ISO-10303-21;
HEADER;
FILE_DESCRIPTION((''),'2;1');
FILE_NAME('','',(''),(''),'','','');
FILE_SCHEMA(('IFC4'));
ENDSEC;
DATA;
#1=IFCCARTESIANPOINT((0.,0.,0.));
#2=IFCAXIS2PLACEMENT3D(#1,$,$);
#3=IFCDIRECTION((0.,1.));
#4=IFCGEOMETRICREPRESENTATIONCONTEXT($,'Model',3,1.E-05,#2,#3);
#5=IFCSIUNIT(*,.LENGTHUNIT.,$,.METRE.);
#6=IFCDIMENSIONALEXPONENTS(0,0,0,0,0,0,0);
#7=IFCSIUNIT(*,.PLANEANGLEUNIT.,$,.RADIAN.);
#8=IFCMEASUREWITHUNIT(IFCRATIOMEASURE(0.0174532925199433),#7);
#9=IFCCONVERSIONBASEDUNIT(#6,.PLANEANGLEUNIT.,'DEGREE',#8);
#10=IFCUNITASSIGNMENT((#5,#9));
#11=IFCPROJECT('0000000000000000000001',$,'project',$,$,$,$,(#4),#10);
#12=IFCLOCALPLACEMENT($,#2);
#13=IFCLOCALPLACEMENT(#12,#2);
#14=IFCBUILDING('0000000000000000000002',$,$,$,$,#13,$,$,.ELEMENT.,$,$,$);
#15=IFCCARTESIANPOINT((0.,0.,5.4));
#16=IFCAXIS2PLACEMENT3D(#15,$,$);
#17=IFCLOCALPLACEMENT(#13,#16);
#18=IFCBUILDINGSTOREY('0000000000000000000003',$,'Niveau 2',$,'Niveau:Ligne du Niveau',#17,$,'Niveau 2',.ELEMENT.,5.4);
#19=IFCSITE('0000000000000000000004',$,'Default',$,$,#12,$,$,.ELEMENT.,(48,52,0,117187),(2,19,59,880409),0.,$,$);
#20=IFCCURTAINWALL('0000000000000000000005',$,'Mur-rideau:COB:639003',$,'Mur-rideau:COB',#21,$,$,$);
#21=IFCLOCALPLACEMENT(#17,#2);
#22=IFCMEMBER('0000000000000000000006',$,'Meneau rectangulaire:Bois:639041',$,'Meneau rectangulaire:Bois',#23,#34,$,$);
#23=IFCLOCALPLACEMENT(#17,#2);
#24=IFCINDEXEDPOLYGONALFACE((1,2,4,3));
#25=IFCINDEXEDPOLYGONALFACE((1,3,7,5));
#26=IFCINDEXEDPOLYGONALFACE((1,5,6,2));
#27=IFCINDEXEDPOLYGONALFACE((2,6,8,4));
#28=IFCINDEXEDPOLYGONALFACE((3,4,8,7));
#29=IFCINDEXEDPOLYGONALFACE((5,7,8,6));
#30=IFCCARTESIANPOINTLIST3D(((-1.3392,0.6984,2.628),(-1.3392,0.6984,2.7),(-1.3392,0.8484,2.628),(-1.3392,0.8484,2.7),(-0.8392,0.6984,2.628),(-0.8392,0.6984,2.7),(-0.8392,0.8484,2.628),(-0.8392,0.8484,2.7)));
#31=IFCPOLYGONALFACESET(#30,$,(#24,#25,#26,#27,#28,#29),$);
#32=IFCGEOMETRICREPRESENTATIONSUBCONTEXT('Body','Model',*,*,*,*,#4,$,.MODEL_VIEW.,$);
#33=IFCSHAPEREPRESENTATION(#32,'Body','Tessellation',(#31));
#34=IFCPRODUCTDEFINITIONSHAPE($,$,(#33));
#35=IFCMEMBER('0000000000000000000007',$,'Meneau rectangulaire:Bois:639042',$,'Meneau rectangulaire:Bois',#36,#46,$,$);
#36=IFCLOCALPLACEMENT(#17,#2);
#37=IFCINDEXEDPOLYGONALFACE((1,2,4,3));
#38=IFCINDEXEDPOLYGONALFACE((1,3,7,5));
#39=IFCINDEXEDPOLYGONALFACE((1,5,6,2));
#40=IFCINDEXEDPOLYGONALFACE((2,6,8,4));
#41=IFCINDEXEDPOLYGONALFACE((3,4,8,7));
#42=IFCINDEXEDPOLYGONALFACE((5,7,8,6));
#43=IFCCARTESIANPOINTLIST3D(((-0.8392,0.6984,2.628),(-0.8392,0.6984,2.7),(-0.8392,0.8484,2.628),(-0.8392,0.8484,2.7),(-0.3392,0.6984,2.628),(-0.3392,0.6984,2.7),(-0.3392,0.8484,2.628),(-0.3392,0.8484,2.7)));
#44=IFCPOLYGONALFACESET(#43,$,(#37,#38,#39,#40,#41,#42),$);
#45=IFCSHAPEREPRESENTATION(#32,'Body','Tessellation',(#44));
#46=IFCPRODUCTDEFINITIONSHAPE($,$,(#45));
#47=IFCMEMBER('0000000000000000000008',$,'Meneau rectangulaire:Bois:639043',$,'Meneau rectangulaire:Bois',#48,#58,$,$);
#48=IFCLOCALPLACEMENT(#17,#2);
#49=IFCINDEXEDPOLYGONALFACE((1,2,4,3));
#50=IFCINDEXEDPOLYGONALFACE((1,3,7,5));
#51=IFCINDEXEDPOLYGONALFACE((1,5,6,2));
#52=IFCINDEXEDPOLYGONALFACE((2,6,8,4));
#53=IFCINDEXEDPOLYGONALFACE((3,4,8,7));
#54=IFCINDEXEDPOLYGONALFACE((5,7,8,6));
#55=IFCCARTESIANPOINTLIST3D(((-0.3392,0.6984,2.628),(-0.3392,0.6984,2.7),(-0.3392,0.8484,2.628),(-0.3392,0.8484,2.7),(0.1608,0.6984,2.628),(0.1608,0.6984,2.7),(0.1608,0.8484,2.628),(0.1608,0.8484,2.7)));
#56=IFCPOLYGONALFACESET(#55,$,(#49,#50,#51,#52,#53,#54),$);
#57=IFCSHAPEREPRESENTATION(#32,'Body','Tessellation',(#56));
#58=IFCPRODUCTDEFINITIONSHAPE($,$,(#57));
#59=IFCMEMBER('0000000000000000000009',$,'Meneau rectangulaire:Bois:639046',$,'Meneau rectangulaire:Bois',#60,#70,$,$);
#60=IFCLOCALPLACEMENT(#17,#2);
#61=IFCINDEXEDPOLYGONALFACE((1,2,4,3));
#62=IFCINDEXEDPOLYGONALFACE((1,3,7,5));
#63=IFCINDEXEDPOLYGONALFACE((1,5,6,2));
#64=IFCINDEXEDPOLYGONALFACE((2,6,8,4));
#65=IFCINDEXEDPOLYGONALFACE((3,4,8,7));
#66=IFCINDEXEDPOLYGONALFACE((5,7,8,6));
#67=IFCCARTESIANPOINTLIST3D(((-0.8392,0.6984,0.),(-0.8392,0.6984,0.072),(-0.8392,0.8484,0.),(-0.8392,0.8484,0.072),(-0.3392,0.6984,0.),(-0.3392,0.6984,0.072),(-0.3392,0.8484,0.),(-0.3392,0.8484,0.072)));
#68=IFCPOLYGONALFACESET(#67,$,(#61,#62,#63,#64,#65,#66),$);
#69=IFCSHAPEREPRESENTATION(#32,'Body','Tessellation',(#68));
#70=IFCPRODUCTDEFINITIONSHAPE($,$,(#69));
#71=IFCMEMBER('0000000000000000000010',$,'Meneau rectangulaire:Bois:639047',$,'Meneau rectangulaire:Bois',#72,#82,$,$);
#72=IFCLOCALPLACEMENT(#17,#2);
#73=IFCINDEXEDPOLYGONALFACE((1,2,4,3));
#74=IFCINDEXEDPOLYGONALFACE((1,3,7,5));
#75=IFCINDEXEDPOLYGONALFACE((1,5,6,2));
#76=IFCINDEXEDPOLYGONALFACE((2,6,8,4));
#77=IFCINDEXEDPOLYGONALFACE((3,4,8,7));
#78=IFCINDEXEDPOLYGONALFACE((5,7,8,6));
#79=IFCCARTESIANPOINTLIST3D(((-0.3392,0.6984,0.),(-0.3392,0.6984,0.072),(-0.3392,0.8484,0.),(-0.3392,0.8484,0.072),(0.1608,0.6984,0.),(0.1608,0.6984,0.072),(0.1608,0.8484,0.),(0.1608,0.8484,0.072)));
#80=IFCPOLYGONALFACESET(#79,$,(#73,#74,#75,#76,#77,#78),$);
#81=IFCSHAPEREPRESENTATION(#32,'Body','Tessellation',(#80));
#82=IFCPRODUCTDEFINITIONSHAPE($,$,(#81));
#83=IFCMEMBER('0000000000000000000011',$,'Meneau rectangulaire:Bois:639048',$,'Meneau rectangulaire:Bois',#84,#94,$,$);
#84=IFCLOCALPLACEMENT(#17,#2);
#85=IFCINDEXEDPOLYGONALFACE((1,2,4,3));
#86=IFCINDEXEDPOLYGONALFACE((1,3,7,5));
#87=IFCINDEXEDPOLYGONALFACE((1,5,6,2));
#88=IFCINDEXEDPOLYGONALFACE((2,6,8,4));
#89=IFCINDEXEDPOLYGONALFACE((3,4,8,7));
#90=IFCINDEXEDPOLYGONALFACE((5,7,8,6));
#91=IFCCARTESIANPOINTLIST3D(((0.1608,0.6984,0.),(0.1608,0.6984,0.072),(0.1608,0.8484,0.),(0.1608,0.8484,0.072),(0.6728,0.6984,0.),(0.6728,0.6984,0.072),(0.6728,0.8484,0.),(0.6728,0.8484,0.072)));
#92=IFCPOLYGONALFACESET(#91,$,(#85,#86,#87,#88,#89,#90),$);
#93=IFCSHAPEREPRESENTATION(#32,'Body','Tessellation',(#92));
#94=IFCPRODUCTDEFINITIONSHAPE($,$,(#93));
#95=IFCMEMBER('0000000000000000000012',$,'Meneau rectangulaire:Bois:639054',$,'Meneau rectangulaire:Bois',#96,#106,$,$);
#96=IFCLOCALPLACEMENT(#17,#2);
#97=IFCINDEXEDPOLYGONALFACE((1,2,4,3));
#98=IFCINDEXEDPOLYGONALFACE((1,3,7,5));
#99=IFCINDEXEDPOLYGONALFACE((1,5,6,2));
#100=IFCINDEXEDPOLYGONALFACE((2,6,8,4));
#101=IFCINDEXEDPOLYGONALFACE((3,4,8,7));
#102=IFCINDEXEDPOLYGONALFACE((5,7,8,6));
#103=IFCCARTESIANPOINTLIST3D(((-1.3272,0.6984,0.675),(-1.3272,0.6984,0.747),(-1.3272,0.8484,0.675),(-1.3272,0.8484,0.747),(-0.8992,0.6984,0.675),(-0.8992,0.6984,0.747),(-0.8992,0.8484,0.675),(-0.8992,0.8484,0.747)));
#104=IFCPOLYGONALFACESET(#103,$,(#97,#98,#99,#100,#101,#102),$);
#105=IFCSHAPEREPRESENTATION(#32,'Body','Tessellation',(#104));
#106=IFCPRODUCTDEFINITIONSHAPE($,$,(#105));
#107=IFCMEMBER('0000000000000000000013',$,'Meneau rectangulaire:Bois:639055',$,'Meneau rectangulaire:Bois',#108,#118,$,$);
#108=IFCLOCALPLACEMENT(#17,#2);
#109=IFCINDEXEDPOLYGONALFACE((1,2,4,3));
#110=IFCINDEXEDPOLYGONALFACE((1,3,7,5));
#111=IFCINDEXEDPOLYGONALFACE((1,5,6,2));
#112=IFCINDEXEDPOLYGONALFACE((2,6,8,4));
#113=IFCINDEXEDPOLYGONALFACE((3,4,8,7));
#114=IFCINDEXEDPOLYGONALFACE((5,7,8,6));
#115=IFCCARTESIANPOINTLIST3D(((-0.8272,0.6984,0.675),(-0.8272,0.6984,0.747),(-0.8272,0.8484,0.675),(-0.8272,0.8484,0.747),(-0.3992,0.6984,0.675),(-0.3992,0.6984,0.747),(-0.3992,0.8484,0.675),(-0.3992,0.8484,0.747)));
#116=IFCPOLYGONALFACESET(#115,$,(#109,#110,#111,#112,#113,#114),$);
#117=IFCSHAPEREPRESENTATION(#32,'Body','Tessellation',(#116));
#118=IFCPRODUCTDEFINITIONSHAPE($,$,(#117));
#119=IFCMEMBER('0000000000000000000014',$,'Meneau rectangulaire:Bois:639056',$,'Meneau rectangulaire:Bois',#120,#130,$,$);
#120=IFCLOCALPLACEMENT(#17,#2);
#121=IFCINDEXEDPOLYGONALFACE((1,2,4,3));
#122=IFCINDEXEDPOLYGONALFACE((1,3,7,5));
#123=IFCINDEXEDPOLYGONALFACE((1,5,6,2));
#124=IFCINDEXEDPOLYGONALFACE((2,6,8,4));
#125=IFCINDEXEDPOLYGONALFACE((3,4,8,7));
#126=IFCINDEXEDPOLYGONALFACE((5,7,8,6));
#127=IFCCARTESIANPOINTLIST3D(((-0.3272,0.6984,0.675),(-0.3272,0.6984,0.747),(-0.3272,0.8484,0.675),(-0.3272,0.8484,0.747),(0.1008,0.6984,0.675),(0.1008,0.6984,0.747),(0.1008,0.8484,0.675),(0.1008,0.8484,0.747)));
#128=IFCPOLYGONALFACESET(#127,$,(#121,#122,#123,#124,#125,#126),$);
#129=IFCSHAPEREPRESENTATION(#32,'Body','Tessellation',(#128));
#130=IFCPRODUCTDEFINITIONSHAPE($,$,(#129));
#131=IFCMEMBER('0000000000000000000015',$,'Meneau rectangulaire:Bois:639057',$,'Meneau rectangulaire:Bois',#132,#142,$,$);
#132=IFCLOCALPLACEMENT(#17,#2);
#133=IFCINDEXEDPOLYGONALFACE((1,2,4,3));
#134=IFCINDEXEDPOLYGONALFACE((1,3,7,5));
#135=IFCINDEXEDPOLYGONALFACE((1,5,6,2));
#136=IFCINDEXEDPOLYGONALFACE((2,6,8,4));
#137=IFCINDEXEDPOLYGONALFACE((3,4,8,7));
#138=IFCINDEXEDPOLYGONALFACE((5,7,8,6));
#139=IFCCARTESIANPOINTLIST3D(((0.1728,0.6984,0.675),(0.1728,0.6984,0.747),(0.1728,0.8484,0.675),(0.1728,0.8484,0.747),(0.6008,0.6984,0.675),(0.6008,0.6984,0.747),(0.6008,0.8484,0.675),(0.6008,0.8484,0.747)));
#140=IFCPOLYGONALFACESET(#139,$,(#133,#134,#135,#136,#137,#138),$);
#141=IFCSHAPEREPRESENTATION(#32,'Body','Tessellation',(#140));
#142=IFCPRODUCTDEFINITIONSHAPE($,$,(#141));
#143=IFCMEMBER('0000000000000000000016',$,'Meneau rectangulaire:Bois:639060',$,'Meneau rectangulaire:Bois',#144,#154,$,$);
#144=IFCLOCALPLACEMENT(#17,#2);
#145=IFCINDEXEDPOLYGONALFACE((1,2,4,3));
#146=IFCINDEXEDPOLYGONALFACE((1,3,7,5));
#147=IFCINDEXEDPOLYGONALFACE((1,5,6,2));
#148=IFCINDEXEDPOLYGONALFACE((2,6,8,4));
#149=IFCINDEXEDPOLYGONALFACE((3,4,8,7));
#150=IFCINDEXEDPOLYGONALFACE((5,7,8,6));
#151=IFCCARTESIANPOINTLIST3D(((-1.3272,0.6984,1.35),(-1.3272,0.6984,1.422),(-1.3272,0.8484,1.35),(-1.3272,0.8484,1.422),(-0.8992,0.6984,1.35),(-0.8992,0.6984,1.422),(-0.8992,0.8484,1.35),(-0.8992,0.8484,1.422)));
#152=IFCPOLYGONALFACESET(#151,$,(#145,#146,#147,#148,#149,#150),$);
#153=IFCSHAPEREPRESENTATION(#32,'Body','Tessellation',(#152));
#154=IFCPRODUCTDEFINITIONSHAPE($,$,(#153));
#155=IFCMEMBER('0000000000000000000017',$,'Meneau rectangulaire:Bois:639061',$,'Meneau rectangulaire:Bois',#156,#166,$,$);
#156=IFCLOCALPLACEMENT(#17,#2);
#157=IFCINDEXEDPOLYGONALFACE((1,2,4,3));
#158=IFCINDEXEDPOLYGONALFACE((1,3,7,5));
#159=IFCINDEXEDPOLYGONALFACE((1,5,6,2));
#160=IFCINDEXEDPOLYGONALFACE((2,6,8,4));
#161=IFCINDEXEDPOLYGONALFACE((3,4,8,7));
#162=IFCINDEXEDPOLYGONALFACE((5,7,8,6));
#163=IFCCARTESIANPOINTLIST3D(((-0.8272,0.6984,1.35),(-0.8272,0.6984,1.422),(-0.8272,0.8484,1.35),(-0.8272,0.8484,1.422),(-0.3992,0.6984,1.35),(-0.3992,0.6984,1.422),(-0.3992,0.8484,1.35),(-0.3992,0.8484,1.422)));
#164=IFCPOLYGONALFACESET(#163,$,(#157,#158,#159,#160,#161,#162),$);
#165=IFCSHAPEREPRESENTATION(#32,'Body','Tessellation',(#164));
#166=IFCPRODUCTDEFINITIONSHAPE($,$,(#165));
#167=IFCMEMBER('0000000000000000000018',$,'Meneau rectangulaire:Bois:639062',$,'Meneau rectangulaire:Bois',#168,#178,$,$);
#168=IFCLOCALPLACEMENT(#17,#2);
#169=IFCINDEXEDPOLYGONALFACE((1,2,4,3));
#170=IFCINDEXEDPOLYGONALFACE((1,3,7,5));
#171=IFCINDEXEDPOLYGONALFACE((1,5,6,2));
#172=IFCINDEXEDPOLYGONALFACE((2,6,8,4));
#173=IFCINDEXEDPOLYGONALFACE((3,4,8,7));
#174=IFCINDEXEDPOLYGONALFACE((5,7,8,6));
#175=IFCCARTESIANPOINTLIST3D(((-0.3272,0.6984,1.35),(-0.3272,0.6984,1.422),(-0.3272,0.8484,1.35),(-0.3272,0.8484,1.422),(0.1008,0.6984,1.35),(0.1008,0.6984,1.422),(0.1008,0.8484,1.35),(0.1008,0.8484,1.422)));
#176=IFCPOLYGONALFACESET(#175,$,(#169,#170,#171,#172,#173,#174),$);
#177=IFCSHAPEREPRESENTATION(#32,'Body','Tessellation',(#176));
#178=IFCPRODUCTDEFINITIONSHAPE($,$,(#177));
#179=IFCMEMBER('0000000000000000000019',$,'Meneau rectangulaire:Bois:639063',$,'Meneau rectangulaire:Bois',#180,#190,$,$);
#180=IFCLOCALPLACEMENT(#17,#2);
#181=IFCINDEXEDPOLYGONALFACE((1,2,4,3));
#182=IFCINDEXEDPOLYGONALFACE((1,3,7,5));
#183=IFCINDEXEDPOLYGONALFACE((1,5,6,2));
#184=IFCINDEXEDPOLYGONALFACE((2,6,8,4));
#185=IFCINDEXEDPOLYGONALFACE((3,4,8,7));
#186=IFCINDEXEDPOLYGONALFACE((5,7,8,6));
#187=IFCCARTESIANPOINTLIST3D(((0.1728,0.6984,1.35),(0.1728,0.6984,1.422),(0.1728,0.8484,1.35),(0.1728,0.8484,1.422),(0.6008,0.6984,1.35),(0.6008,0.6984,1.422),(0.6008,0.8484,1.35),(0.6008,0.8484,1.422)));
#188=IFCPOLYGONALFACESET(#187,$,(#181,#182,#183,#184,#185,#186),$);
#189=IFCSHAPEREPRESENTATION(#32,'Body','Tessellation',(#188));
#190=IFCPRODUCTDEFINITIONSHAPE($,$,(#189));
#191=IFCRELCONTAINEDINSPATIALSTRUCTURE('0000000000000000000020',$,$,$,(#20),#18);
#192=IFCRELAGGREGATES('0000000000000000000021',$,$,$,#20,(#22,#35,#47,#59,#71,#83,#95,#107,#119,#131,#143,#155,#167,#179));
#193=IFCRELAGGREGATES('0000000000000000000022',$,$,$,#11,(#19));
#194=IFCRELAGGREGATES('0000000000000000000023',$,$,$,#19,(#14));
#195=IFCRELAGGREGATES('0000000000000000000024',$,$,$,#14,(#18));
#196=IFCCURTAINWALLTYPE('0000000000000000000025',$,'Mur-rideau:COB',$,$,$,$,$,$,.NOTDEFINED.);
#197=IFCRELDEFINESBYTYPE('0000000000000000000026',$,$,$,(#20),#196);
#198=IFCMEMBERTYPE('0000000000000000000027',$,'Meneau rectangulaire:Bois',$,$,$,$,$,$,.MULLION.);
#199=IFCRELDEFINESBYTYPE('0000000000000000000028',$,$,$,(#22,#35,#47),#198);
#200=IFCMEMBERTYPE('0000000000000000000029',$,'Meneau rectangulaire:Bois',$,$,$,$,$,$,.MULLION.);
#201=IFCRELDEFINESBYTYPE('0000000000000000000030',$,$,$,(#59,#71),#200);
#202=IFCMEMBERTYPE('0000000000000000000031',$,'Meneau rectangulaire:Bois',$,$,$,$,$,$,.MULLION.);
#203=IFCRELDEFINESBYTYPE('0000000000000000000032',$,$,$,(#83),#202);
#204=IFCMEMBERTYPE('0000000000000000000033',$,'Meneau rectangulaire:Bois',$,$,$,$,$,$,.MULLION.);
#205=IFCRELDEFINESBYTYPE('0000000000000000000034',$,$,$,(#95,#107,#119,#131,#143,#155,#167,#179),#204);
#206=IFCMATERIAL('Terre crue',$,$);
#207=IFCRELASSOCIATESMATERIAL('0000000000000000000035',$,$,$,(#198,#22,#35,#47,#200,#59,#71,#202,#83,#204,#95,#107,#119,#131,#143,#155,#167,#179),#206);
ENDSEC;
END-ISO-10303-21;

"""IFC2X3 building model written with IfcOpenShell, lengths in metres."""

from ifc_helpers import new_model, entity, si_unit, converted_unit, direction, frame, origin, origin_2d_with_axis, place, context, subcontext, project, spatial, rectangle, extrude, source, transform, mapped, material, type_object, type_shapes, element, aggregate, save


model = new_model("IFC2X3")

# Units and contexts
model_context = context("Model", 3, precision=1e-05, world=origin(), true_north=direction((0.0, 1.0)))
body_context = subcontext(model_context, "Body", "Model", "MODEL_VIEW")
ifc_project = project(units=[si_unit("LENGTHUNIT", "METRE"), converted_unit("PLANEANGLEUNIT", "DEGREE", entity("IfcRatioMeasure", 0.0174532925199433), si_unit("PLANEANGLEUNIT", "RADIAN"), dimensions=[0, 0, 0, 0, 0, 0, 0])], contexts=[model_context])

# Site, building, storey
site_placement = place(None, origin())
site = spatial("IfcSite", under=ifc_project, at=site_placement, Name="Default", CompositionType="ELEMENT", RefLatitude=(48, 52, 0, 117187), RefLongitude=(2, 19, 59, 880409), RefElevation=0.0)
building_placement = place(site_placement, origin())
building = spatial("IfcBuilding", under=site, at=building_placement, CompositionType="ELEMENT")
storey_placement = place(building_placement, frame((0.0, 0.0, 5.4)))
storey = spatial("IfcBuildingStorey", under=building, at=storey_placement, Name="Niveau 2", ObjectType="Niveau:Ligne du Niveau", LongName="Niveau 2", CompositionType="ELEMENT", Elevation=5.4)

# Curtain wall, members
curtain_wall_type_1 = type_object("IfcCurtainWallType", Name="Mur-rideau:COB", PredefinedType="NOTDEFINED")
curtain_wall_1_placement = place(storey_placement, frame((0.0, 0.0, -5.4)))
curtain_wall_1 = element("IfcCurtainWall", 1, at=curtain_wall_1_placement, inside=storey, type_object=curtain_wall_type_1, Name="Mur-rideau:COB:639003", ObjectType="Mur-rideau:COB")
ifc_material_1 = material(Name="Terre crue")
member_type_1 = type_object("IfcMemberType", Name="Meneau rectangulaire:Bois", PredefinedType="MULLION", material=ifc_material_1)
shared_shape_1 = source(origin(), body_context, "Body", "SweptSolid", [
    extrude(rectangle(XDim=0.15, YDim=0.072, at=origin_2d_with_axis()), frame((-0.036, 0.0, -0.5), z_axis=(0.0, 0.0, 1.0), x_axis=(0.0, -1.0, 0.0)), (0.0, 0.0, 1.0), 0.5),
])
type_shapes(member_type_1, [shared_shape_1])
member_1_placement = place(storey_placement, frame((-0.8392, 0.7734, 2.7), z_axis=(1.0, 0.0, 0.0), x_axis=(0.0, 0.0, 1.0)))
member_1 = element("IfcMember", 2, at=member_1_placement, type_object=member_type_1, material=ifc_material_1, Name="Meneau rectangulaire:Bois:639041", ObjectType="Meneau rectangulaire:Bois", context=body_context, shape_type="MappedRepresentation", body=[
    mapped(shared_shape_1, transform((0.0, 0.0, 0.0), scale=1.0)),
])
member_2_placement = place(storey_placement, frame((-0.3392, 0.7734, 2.7), z_axis=(1.0, 0.0, 0.0), x_axis=(0.0, 0.0, 1.0)))
member_2 = element("IfcMember", 3, at=member_2_placement, type_object=member_type_1, material=ifc_material_1, Name="Meneau rectangulaire:Bois:639042", ObjectType="Meneau rectangulaire:Bois", context=body_context, shape_type="MappedRepresentation", body=[
    mapped(shared_shape_1, transform((0.0, 0.0, 0.0), scale=1.0)),
])
member_3_placement = place(storey_placement, frame((0.1608, 0.7734, 2.7), z_axis=(1.0, 0.0, 0.0), x_axis=(0.0, 0.0, 1.0)))
member_3 = element("IfcMember", 4, at=member_3_placement, type_object=member_type_1, material=ifc_material_1, Name="Meneau rectangulaire:Bois:639043", ObjectType="Meneau rectangulaire:Bois", context=body_context, shape_type="MappedRepresentation", body=[
    mapped(shared_shape_1, transform((0.0, 0.0, 0.0), scale=1.0)),
])
member_type_2 = type_object("IfcMemberType", Name="Meneau rectangulaire:Bois", PredefinedType="MULLION", material=ifc_material_1)
shared_shape_2 = source(origin(), body_context, "Body", "SweptSolid", [
    extrude(rectangle(XDim=0.15, YDim=0.072, at=origin_2d_with_axis()), frame((-0.036, 0.0, -0.5), z_axis=(0.0, 0.0, 1.0), x_axis=(0.0, -1.0, 0.0)), (0.0, 0.0, 1.0), 0.5),
])
type_shapes(member_type_2, [shared_shape_2])
member_4_placement = place(storey_placement, frame((-0.8392, 0.7734, 0.0), z_axis=(-1.0, 0.0, 0.0), x_axis=(0.0, 0.0, -1.0)))
member_4 = element("IfcMember", 5, at=member_4_placement, type_object=member_type_2, material=ifc_material_1, Name="Meneau rectangulaire:Bois:639046", ObjectType="Meneau rectangulaire:Bois", context=body_context, shape_type="MappedRepresentation", body=[
    mapped(shared_shape_2, transform((0.0, 0.0, 0.0), scale=1.0)),
])
member_5_placement = place(storey_placement, frame((-0.3392, 0.7734, 0.0), z_axis=(-1.0, 0.0, 0.0), x_axis=(0.0, 0.0, -1.0)))
member_5 = element("IfcMember", 6, at=member_5_placement, type_object=member_type_2, material=ifc_material_1, Name="Meneau rectangulaire:Bois:639047", ObjectType="Meneau rectangulaire:Bois", context=body_context, shape_type="MappedRepresentation", body=[
    mapped(shared_shape_2, transform((0.0, 0.0, 0.0), scale=1.0)),
])
member_type_3 = type_object("IfcMemberType", Name="Meneau rectangulaire:Bois", PredefinedType="MULLION", material=ifc_material_1)
shared_shape_3 = source(origin(), body_context, "Body", "SweptSolid", [
    extrude(rectangle(XDim=0.15, YDim=0.072, at=origin_2d_with_axis()), frame((-0.036, 0.0, -0.512), z_axis=(0.0, 0.0, 1.0), x_axis=(0.0, -1.0, 0.0)), (0.0, 0.0, 1.0), 0.512),
])
type_shapes(member_type_3, [shared_shape_3])
member_6_placement = place(storey_placement, frame((0.1608, 0.7734, 0.0), z_axis=(-1.0, 0.0, 0.0), x_axis=(0.0, 0.0, -1.0)))
member_6 = element("IfcMember", 7, at=member_6_placement, type_object=member_type_3, material=ifc_material_1, Name="Meneau rectangulaire:Bois:639048", ObjectType="Meneau rectangulaire:Bois", context=body_context, shape_type="MappedRepresentation", body=[
    mapped(shared_shape_3, transform((0.0, 0.0, 0.0), scale=1.0)),
])
member_type_4 = type_object("IfcMemberType", Name="Meneau rectangulaire:Bois", PredefinedType="MULLION", material=ifc_material_1)
shared_shape_4 = source(origin(), body_context, "Body", "SweptSolid", [
    extrude(rectangle(XDim=0.15, YDim=0.072, at=origin_2d_with_axis()), frame((-0.024, 0.0, -0.428), z_axis=(0.0, 0.0, 1.0), x_axis=(0.0, -1.0, 0.0)), (0.0, 0.0, 1.0), 0.428),
])
type_shapes(member_type_4, [shared_shape_4])
member_7_placement = place(storey_placement, frame((-0.8992, 0.7734, 0.735), z_axis=(1.0, 0.0, 0.0), x_axis=(0.0, 0.0, 1.0)))
member_7 = element("IfcMember", 8, at=member_7_placement, type_object=member_type_4, material=ifc_material_1, Name="Meneau rectangulaire:Bois:639054", ObjectType="Meneau rectangulaire:Bois", context=body_context, shape_type="MappedRepresentation", body=[
    mapped(shared_shape_4, transform((0.0, 0.0, 0.0), scale=1.0)),
])
member_8_placement = place(storey_placement, frame((-0.3992, 0.7734, 0.735), z_axis=(1.0, 0.0, 0.0), x_axis=(0.0, 0.0, 1.0)))
member_8 = element("IfcMember", 9, at=member_8_placement, type_object=member_type_4, material=ifc_material_1, Name="Meneau rectangulaire:Bois:639055", ObjectType="Meneau rectangulaire:Bois", context=body_context, shape_type="MappedRepresentation", body=[
    mapped(shared_shape_4, transform((0.0, 0.0, 0.0), scale=1.0)),
])
member_9_placement = place(storey_placement, frame((0.1008, 0.7734, 0.735), z_axis=(1.0, 0.0, 0.0), x_axis=(0.0, 0.0, 1.0)))
member_9 = element("IfcMember", 10, at=member_9_placement, type_object=member_type_4, material=ifc_material_1, Name="Meneau rectangulaire:Bois:639056", ObjectType="Meneau rectangulaire:Bois", context=body_context, shape_type="MappedRepresentation", body=[
    mapped(shared_shape_4, transform((0.0, 0.0, 0.0), scale=1.0)),
])
member_10_placement = place(storey_placement, frame((0.6008, 0.7734, 0.735), z_axis=(1.0, 0.0, 0.0), x_axis=(0.0, 0.0, 1.0)))
member_10 = element("IfcMember", 11, at=member_10_placement, type_object=member_type_4, material=ifc_material_1, Name="Meneau rectangulaire:Bois:639057", ObjectType="Meneau rectangulaire:Bois", context=body_context, shape_type="MappedRepresentation", body=[
    mapped(shared_shape_4, transform((0.0, 0.0, 0.0), scale=1.0)),
])
member_11_placement = place(storey_placement, frame((-0.8992, 0.7734, 1.41), z_axis=(1.0, 0.0, 0.0), x_axis=(0.0, 0.0, 1.0)))
member_11 = element("IfcMember", 12, at=member_11_placement, type_object=member_type_4, material=ifc_material_1, Name="Meneau rectangulaire:Bois:639060", ObjectType="Meneau rectangulaire:Bois", context=body_context, shape_type="MappedRepresentation", body=[
    mapped(shared_shape_4, transform((0.0, 0.0, 0.0), scale=1.0)),
])
member_12_placement = place(storey_placement, frame((-0.3992, 0.7734, 1.41), z_axis=(1.0, 0.0, 0.0), x_axis=(0.0, 0.0, 1.0)))
member_12 = element("IfcMember", 13, at=member_12_placement, type_object=member_type_4, material=ifc_material_1, Name="Meneau rectangulaire:Bois:639061", ObjectType="Meneau rectangulaire:Bois", context=body_context, shape_type="MappedRepresentation", body=[
    mapped(shared_shape_4, transform((0.0, 0.0, 0.0), scale=1.0)),
])
member_13_placement = place(storey_placement, frame((0.1008, 0.7734, 1.41), z_axis=(1.0, 0.0, 0.0), x_axis=(0.0, 0.0, 1.0)))
member_13 = element("IfcMember", 14, at=member_13_placement, type_object=member_type_4, material=ifc_material_1, Name="Meneau rectangulaire:Bois:639062", ObjectType="Meneau rectangulaire:Bois", context=body_context, shape_type="MappedRepresentation", body=[
    mapped(shared_shape_4, transform((0.0, 0.0, 0.0), scale=1.0)),
])
member_14_placement = place(storey_placement, frame((0.6008, 0.7734, 1.41), z_axis=(1.0, 0.0, 0.0), x_axis=(0.0, 0.0, 1.0)))
member_14 = element("IfcMember", 15, at=member_14_placement, type_object=member_type_4, material=ifc_material_1, Name="Meneau rectangulaire:Bois:639063", ObjectType="Meneau rectangulaire:Bois", context=body_context, shape_type="MappedRepresentation", body=[
    mapped(shared_shape_4, transform((0.0, 0.0, 0.0), scale=1.0)),
])
aggregate(curtain_wall_1, [member_1, member_2, member_3, member_4, member_5, member_6, member_7, member_8, member_9, member_10, member_11, member_12, member_13, member_14])

save(model, "model.ifc")
